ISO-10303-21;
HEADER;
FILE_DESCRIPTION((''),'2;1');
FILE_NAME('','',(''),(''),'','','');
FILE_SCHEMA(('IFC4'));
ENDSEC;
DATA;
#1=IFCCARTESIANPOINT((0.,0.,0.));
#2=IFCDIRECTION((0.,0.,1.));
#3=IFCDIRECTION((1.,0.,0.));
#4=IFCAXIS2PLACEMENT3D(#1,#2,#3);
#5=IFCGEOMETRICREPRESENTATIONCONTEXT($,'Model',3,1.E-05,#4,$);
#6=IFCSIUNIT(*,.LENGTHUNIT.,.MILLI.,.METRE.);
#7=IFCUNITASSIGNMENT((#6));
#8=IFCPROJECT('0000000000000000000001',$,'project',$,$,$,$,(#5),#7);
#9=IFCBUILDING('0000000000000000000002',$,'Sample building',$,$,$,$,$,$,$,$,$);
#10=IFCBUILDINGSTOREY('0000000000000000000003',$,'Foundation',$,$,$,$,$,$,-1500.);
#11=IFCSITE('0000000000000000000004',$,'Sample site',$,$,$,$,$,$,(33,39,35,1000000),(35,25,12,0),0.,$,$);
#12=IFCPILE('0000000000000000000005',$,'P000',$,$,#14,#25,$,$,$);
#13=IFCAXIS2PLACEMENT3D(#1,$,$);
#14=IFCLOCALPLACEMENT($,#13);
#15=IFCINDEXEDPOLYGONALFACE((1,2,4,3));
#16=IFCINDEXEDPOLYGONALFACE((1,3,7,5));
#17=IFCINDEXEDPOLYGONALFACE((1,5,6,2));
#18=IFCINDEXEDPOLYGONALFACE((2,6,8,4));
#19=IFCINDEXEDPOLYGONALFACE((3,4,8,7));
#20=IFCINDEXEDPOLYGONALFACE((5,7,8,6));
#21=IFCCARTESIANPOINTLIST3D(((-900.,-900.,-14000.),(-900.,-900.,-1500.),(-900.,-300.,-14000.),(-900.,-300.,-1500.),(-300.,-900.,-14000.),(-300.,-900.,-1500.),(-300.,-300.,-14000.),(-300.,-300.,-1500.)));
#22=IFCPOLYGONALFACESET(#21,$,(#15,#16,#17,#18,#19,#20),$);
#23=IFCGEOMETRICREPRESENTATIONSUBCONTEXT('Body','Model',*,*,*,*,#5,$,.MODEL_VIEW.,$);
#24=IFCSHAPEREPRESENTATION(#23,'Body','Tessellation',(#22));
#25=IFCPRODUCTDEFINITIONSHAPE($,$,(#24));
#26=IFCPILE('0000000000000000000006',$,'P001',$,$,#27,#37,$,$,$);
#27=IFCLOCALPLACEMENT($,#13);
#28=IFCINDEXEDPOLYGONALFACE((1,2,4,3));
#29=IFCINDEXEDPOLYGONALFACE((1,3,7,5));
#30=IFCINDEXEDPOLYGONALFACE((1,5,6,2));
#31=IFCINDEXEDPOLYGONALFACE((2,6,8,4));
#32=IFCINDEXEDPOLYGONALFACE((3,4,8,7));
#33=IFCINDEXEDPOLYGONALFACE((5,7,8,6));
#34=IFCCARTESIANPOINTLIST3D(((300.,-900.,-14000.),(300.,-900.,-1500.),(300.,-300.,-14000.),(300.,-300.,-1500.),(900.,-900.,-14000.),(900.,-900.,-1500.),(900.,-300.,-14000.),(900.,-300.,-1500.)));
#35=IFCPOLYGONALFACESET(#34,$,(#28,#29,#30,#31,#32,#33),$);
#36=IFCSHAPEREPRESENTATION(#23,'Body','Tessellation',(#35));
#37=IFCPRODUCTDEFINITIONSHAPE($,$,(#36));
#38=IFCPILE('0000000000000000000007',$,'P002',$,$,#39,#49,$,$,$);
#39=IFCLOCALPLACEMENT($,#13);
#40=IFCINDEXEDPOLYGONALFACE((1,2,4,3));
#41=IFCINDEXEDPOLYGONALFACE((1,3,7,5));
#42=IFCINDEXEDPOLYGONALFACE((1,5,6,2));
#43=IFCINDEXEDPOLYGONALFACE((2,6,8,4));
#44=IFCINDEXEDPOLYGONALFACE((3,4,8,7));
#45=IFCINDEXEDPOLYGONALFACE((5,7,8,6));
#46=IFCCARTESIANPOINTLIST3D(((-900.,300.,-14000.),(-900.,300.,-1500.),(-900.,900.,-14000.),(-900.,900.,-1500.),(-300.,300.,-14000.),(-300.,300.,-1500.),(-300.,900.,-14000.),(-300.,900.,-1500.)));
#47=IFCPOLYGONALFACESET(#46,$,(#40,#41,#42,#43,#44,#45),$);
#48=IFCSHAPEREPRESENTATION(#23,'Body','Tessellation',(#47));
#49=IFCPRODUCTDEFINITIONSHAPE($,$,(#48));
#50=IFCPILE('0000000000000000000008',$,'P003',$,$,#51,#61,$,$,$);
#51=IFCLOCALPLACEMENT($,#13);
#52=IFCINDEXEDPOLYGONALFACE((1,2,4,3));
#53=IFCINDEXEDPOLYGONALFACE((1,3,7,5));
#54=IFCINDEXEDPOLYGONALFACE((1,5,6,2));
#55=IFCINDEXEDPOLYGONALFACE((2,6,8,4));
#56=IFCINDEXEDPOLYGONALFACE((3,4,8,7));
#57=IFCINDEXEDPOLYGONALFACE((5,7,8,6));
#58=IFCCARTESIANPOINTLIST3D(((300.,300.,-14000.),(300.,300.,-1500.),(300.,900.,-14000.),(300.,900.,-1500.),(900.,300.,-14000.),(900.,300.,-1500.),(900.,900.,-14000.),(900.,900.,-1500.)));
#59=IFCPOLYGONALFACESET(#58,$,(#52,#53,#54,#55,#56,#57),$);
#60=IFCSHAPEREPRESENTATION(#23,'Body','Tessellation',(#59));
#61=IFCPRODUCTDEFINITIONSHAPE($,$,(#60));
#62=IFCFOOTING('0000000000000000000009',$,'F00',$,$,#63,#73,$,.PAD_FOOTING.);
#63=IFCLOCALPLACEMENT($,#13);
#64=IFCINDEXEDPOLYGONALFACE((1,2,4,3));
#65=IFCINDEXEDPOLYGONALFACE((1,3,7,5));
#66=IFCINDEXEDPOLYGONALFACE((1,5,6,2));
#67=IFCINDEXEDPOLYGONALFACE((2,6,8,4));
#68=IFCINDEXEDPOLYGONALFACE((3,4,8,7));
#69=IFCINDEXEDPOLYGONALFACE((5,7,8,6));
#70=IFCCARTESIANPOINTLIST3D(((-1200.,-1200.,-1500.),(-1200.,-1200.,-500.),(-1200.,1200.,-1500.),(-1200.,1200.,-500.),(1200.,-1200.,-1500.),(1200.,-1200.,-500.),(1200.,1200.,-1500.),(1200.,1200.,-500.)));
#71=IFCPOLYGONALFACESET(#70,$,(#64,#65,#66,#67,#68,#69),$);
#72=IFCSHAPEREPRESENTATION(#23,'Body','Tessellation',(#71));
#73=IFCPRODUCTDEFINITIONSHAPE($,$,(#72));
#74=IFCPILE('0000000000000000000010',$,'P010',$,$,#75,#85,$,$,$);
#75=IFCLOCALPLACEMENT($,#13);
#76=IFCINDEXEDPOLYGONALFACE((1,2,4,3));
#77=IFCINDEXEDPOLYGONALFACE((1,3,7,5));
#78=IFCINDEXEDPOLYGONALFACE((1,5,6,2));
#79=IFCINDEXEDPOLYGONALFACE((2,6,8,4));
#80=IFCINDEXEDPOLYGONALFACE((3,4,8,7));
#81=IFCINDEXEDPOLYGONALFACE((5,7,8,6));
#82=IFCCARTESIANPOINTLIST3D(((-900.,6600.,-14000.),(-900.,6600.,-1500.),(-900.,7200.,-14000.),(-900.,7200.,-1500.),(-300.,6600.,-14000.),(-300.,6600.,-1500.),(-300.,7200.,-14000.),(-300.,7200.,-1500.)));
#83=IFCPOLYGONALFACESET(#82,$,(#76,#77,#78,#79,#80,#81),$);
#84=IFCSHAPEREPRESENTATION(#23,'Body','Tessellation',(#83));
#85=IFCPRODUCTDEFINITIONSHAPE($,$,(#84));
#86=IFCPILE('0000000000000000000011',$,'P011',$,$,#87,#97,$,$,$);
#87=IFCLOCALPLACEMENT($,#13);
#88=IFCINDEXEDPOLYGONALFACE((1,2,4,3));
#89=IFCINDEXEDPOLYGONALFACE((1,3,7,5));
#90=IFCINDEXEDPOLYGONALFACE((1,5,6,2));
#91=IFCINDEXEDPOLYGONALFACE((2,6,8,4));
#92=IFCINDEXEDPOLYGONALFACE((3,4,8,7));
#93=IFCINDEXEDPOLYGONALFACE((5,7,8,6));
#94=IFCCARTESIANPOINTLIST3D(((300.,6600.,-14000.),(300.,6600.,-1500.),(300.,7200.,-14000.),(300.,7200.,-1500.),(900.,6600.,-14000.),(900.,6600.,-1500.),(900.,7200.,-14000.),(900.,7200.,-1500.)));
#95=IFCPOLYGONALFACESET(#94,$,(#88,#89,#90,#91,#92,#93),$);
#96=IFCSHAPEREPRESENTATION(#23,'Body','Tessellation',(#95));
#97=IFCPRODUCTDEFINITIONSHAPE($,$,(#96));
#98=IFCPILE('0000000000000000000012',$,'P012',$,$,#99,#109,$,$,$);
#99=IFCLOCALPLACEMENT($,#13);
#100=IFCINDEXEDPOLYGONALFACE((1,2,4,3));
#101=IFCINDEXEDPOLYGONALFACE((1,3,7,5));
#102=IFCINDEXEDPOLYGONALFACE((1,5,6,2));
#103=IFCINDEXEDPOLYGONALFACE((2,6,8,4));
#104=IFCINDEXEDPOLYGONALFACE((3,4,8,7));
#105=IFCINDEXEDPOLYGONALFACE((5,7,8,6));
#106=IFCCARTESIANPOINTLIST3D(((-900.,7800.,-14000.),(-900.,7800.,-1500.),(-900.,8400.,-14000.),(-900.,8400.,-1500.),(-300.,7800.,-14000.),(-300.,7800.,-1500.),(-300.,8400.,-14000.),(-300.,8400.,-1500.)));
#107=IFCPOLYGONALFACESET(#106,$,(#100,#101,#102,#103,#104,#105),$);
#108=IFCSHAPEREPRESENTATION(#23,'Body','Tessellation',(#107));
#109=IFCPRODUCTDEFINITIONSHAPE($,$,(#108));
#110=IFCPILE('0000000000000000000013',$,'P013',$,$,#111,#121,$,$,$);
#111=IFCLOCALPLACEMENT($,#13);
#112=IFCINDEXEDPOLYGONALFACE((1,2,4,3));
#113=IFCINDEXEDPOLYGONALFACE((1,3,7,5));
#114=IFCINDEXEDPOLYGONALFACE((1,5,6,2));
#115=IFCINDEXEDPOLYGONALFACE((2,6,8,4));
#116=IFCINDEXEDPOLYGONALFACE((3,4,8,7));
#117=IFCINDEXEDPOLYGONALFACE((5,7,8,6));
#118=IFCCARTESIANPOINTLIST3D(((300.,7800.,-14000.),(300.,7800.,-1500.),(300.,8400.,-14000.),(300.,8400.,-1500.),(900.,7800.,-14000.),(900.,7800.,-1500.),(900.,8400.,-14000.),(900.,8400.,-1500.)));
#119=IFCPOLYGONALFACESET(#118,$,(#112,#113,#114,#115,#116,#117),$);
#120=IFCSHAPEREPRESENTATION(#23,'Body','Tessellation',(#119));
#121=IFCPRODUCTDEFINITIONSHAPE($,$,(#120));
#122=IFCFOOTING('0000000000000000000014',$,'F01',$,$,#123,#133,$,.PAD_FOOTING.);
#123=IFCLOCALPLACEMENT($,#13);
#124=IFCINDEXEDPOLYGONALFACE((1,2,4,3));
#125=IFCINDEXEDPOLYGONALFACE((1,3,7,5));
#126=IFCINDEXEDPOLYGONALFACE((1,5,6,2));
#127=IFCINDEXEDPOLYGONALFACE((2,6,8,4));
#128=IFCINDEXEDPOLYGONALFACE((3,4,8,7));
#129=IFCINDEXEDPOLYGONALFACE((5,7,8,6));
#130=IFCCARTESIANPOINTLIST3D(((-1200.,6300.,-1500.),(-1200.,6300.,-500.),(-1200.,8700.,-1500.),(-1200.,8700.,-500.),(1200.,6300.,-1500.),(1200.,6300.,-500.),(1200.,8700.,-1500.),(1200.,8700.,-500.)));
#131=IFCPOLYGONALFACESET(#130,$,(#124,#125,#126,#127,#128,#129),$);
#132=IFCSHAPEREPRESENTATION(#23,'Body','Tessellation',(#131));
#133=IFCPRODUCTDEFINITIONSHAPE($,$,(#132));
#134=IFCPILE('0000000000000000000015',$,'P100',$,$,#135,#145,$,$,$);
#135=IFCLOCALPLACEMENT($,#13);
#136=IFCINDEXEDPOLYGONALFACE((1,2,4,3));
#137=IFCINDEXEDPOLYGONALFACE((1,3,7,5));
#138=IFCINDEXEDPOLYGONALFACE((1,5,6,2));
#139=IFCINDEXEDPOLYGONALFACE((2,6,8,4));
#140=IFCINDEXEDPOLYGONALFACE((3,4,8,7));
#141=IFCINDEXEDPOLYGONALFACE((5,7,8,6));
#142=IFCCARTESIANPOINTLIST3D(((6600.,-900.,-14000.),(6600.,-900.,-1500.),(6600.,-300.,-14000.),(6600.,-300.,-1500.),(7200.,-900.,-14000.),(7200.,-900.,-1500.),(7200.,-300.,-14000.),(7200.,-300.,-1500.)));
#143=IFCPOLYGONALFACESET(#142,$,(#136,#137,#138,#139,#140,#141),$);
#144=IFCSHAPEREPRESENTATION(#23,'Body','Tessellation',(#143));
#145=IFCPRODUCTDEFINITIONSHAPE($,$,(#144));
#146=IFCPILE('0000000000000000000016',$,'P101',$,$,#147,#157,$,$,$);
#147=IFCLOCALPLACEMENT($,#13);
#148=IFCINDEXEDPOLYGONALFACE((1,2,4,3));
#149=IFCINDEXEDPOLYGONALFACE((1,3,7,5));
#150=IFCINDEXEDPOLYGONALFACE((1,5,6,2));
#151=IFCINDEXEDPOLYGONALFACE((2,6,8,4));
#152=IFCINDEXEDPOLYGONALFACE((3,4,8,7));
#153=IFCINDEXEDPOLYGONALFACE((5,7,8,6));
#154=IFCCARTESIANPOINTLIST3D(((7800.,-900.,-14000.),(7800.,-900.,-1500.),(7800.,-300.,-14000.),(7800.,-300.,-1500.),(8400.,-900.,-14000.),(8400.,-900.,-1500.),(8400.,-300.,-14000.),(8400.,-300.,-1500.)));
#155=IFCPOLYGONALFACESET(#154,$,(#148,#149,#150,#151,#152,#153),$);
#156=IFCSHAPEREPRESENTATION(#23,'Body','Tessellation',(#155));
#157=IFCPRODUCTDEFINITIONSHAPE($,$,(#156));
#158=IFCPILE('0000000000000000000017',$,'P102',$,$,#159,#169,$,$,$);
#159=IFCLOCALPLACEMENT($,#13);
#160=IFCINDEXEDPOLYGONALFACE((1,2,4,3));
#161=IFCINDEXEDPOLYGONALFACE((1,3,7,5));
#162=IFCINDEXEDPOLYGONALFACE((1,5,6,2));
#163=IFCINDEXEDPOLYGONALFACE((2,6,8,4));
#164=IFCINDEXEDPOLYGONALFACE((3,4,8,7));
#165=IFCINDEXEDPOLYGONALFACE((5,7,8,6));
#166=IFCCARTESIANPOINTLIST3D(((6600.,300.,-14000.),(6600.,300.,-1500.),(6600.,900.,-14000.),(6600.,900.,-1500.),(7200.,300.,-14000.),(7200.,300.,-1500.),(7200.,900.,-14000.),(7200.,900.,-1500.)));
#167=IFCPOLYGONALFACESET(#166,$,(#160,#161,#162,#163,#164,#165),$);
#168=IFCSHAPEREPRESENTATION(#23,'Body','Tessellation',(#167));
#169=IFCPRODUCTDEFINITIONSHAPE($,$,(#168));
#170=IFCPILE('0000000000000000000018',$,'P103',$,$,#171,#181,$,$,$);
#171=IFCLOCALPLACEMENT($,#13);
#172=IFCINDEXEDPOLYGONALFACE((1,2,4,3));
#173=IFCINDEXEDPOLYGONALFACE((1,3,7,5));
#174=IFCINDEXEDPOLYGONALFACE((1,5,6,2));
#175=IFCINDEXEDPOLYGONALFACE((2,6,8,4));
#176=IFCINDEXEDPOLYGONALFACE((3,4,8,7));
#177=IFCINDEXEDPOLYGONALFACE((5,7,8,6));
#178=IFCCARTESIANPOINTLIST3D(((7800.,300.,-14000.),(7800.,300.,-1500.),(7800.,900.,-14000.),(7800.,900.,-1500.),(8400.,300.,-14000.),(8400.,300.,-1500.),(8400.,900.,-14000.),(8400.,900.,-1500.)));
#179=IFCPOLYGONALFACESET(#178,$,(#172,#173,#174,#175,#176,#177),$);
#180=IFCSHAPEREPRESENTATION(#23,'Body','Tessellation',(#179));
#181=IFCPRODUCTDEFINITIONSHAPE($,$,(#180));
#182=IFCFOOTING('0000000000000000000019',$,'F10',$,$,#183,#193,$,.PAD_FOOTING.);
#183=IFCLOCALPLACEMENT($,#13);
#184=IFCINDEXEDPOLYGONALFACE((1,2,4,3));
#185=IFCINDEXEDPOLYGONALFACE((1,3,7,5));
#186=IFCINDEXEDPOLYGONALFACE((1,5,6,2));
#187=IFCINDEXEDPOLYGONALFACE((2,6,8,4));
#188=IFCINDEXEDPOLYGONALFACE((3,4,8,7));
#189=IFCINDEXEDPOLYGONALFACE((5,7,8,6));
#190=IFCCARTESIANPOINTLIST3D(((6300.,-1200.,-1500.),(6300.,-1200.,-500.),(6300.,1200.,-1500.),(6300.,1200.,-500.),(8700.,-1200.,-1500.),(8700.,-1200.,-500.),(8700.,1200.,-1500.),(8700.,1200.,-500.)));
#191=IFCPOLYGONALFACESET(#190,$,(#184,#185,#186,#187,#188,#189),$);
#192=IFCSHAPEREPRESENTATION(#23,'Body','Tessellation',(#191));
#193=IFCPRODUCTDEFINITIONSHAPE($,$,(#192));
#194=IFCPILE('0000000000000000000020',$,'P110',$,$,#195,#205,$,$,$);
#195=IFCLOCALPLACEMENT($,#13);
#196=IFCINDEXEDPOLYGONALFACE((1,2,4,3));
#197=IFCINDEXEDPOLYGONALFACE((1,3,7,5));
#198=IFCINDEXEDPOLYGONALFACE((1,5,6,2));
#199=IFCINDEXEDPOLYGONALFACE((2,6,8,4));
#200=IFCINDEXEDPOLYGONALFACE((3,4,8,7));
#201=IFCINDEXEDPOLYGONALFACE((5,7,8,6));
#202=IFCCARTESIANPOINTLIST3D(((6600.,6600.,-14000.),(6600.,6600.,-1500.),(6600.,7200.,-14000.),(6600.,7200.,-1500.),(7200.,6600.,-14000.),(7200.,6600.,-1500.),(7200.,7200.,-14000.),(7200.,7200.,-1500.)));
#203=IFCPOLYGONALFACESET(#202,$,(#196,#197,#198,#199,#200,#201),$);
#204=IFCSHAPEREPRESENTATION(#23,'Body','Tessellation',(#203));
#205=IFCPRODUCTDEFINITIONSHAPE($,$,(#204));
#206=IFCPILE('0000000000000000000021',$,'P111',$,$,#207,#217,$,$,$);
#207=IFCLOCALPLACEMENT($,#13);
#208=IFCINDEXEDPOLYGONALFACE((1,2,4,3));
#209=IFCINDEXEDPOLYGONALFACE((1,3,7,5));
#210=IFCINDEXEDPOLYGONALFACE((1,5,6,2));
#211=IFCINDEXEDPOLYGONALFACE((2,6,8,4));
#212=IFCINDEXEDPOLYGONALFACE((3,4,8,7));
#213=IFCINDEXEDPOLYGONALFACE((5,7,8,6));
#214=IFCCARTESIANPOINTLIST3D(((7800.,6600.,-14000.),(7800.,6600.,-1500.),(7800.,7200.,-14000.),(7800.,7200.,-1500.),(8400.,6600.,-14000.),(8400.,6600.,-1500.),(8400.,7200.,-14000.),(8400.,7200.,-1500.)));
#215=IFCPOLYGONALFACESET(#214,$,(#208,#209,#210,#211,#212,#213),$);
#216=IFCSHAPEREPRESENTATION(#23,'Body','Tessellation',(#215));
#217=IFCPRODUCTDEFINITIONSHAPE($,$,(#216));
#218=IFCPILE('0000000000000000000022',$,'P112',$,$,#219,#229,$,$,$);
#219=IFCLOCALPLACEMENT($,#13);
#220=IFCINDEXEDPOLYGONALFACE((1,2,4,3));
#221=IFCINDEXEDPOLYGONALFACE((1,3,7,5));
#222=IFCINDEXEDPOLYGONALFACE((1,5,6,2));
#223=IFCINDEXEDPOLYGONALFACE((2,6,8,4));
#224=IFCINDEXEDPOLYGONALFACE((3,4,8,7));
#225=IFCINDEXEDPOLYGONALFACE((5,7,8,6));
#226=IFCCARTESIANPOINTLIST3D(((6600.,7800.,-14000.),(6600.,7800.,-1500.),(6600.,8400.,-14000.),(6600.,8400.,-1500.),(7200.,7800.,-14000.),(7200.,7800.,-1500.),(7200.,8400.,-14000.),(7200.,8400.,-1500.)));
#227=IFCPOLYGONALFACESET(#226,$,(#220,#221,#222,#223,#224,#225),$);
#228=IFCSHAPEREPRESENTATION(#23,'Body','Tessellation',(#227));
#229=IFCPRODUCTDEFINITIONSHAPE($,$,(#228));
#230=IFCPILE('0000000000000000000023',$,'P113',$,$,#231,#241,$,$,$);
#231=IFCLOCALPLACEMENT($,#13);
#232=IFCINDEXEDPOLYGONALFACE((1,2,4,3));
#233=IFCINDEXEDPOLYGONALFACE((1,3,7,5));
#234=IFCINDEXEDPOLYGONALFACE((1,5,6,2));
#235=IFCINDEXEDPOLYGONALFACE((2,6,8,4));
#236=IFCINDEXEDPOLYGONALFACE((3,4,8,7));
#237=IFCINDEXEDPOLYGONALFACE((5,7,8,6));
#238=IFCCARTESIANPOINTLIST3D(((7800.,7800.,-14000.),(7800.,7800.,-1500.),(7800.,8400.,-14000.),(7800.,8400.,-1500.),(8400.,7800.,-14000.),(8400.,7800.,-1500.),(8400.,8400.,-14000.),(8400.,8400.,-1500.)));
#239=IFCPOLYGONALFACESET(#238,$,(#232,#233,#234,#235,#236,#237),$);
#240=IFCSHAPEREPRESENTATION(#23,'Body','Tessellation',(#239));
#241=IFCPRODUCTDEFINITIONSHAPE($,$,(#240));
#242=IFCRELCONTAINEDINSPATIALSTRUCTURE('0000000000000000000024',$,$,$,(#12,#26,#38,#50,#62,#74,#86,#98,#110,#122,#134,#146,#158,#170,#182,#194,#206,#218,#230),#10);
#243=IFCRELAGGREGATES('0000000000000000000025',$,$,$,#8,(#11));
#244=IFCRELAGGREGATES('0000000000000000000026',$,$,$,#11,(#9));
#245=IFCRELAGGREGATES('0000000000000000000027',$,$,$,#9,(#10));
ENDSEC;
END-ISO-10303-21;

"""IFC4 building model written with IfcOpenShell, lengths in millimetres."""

from ifc_helpers import new_model, si_unit, frame, origin_with_axes, place, context, subcontext, project, spatial, indexed_curve, outline, extrude, element, save


model = new_model("IFC4")

# Units and contexts
model_context = context("Model", 3, precision=1e-05, world=origin_with_axes())
body_context = subcontext(model_context, "Body", "Model", "MODEL_VIEW")
ifc_project = project(units=[si_unit("LENGTHUNIT", "METRE", prefix="MILLI")], contexts=[model_context])

# Site, building, storey
site = spatial("IfcSite", under=ifc_project, Name="Sample site", RefLatitude=(33, 39, 35, 1000000), RefLongitude=(35, 25, 12, 0), RefElevation=0.0)
building = spatial("IfcBuilding", under=site, Name="Sample building")
storey = spatial("IfcBuildingStorey", under=building, Name="Foundation", Elevation=-1500.0)

# Piles
for number, where, z_axis, x_axis, name in (
    (1, (-900.0, -900.0, -14000.0), (0.0, 0.0, 1.0), (1.0, 0.0, 0.0), "P000"),
    (2, (300.0, -900.0, -14000.0), (0.0, 0.0, 1.0), (1.0, 0.0, 0.0), "P001"),
    (3, (-900.0, 300.0, -14000.0), (0.0, 0.0, 1.0), (1.0, 0.0, 0.0), "P002"),
    (4, (300.0, 300.0, -14000.0), (0.0, 0.0, 1.0), (1.0, 0.0, 0.0), "P003"),
):
    element("IfcPile", number, at=place(None, frame(where, z_axis=z_axis, x_axis=x_axis)), inside=storey, Name=name, context=body_context, shape_type="SweptSolid", body=[
        extrude(outline(indexed_curve([(0.0, 0.0), (0.0, 600.0), (600.0, 600.0), (600.0, 0.0), (0.0, 0.0)], self_intersect=False)), origin_with_axes(), (0.0, 0.0, 1.0), 12500.0),
    ])

# Footing
footing_1_placement = place(None, frame((-1200.0, -1200.0, -1500.0), z_axis=(0.0, 0.0, 1.0), x_axis=(1.0, 0.0, 0.0)))
element("IfcFooting", 5, at=footing_1_placement, inside=storey, Name="F00", PredefinedType="PAD_FOOTING", context=body_context, shape_type="SweptSolid", body=[
    extrude(outline(indexed_curve([(0.0, 0.0), (0.0, 2400.0), (2400.0, 2400.0), (2400.0, 0.0), (0.0, 0.0)], self_intersect=False)), origin_with_axes(), (0.0, 0.0, 1.0), 1000.0),
])

# Piles
for number, where, z_axis, x_axis, name in (
    (6, (-900.0, 6600.0, -14000.0), (0.0, 0.0, 1.0), (1.0, 0.0, 0.0), "P010"),
    (7, (300.0, 6600.0, -14000.0), (0.0, 0.0, 1.0), (1.0, 0.0, 0.0), "P011"),
    (8, (-900.0, 7800.0, -14000.0), (0.0, 0.0, 1.0), (1.0, 0.0, 0.0), "P012"),
    (9, (300.0, 7800.0, -14000.0), (0.0, 0.0, 1.0), (1.0, 0.0, 0.0), "P013"),
):
    element("IfcPile", number, at=place(None, frame(where, z_axis=z_axis, x_axis=x_axis)), inside=storey, Name=name, context=body_context, shape_type="SweptSolid", body=[
        extrude(outline(indexed_curve([(0.0, 0.0), (0.0, 600.0), (600.0, 600.0), (600.0, 0.0), (0.0, 0.0)], self_intersect=False)), origin_with_axes(), (0.0, 0.0, 1.0), 12500.0),
    ])

# Footing
footing_2_placement = place(None, frame((-1200.0, 6300.0, -1500.0), z_axis=(0.0, 0.0, 1.0), x_axis=(1.0, 0.0, 0.0)))
element("IfcFooting", 10, at=footing_2_placement, inside=storey, Name="F01", PredefinedType="PAD_FOOTING", context=body_context, shape_type="SweptSolid", body=[
    extrude(outline(indexed_curve([(0.0, 0.0), (0.0, 2400.0), (2400.0, 2400.0), (2400.0, 0.0), (0.0, 0.0)], self_intersect=False)), origin_with_axes(), (0.0, 0.0, 1.0), 1000.0),
])

# Piles
for number, where, z_axis, x_axis, name in (
    (11, (6600.0, -900.0, -14000.0), (0.0, 0.0, 1.0), (1.0, 0.0, 0.0), "P100"),
    (12, (7800.0, -900.0, -14000.0), (0.0, 0.0, 1.0), (1.0, 0.0, 0.0), "P101"),
    (13, (6600.0, 300.0, -14000.0), (0.0, 0.0, 1.0), (1.0, 0.0, 0.0), "P102"),
    (14, (7800.0, 300.0, -14000.0), (0.0, 0.0, 1.0), (1.0, 0.0, 0.0), "P103"),
):
    element("IfcPile", number, at=place(None, frame(where, z_axis=z_axis, x_axis=x_axis)), inside=storey, Name=name, context=body_context, shape_type="SweptSolid", body=[
        extrude(outline(indexed_curve([(0.0, 0.0), (0.0, 600.0), (600.0, 600.0), (600.0, 0.0), (0.0, 0.0)], self_intersect=False)), origin_with_axes(), (0.0, 0.0, 1.0), 12500.0),
    ])

# Footing
footing_3_placement = place(None, frame((6300.0, -1200.0, -1500.0), z_axis=(0.0, 0.0, 1.0), x_axis=(1.0, 0.0, 0.0)))
element("IfcFooting", 15, at=footing_3_placement, inside=storey, Name="F10", PredefinedType="PAD_FOOTING", context=body_context, shape_type="SweptSolid", body=[
    extrude(outline(indexed_curve([(0.0, 0.0), (0.0, 2400.0), (2400.0, 2400.0), (2400.0, 0.0), (0.0, 0.0)], self_intersect=False)), origin_with_axes(), (0.0, 0.0, 1.0), 1000.0),
])

# Piles
for number, where, z_axis, x_axis, name in (
    (16, (6600.0, 6600.0, -14000.0), (0.0, 0.0, 1.0), (1.0, 0.0, 0.0), "P110"),
    (17, (7800.0, 6600.0, -14000.0), (0.0, 0.0, 1.0), (1.0, 0.0, 0.0), "P111"),
    (18, (6600.0, 7800.0, -14000.0), (0.0, 0.0, 1.0), (1.0, 0.0, 0.0), "P112"),
    (19, (7800.0, 7800.0, -14000.0), (0.0, 0.0, 1.0), (1.0, 0.0, 0.0), "P113"),
):
    element("IfcPile", number, at=place(None, frame(where, z_axis=z_axis, x_axis=x_axis)), inside=storey, Name=name, context=body_context, shape_type="SweptSolid", body=[
        extrude(outline(indexed_curve([(0.0, 0.0), (0.0, 600.0), (600.0, 600.0), (600.0, 0.0), (0.0, 0.0)], self_intersect=False)), origin_with_axes(), (0.0, 0.0, 1.0), 12500.0),
    ])

save(model, "model.ifc")
